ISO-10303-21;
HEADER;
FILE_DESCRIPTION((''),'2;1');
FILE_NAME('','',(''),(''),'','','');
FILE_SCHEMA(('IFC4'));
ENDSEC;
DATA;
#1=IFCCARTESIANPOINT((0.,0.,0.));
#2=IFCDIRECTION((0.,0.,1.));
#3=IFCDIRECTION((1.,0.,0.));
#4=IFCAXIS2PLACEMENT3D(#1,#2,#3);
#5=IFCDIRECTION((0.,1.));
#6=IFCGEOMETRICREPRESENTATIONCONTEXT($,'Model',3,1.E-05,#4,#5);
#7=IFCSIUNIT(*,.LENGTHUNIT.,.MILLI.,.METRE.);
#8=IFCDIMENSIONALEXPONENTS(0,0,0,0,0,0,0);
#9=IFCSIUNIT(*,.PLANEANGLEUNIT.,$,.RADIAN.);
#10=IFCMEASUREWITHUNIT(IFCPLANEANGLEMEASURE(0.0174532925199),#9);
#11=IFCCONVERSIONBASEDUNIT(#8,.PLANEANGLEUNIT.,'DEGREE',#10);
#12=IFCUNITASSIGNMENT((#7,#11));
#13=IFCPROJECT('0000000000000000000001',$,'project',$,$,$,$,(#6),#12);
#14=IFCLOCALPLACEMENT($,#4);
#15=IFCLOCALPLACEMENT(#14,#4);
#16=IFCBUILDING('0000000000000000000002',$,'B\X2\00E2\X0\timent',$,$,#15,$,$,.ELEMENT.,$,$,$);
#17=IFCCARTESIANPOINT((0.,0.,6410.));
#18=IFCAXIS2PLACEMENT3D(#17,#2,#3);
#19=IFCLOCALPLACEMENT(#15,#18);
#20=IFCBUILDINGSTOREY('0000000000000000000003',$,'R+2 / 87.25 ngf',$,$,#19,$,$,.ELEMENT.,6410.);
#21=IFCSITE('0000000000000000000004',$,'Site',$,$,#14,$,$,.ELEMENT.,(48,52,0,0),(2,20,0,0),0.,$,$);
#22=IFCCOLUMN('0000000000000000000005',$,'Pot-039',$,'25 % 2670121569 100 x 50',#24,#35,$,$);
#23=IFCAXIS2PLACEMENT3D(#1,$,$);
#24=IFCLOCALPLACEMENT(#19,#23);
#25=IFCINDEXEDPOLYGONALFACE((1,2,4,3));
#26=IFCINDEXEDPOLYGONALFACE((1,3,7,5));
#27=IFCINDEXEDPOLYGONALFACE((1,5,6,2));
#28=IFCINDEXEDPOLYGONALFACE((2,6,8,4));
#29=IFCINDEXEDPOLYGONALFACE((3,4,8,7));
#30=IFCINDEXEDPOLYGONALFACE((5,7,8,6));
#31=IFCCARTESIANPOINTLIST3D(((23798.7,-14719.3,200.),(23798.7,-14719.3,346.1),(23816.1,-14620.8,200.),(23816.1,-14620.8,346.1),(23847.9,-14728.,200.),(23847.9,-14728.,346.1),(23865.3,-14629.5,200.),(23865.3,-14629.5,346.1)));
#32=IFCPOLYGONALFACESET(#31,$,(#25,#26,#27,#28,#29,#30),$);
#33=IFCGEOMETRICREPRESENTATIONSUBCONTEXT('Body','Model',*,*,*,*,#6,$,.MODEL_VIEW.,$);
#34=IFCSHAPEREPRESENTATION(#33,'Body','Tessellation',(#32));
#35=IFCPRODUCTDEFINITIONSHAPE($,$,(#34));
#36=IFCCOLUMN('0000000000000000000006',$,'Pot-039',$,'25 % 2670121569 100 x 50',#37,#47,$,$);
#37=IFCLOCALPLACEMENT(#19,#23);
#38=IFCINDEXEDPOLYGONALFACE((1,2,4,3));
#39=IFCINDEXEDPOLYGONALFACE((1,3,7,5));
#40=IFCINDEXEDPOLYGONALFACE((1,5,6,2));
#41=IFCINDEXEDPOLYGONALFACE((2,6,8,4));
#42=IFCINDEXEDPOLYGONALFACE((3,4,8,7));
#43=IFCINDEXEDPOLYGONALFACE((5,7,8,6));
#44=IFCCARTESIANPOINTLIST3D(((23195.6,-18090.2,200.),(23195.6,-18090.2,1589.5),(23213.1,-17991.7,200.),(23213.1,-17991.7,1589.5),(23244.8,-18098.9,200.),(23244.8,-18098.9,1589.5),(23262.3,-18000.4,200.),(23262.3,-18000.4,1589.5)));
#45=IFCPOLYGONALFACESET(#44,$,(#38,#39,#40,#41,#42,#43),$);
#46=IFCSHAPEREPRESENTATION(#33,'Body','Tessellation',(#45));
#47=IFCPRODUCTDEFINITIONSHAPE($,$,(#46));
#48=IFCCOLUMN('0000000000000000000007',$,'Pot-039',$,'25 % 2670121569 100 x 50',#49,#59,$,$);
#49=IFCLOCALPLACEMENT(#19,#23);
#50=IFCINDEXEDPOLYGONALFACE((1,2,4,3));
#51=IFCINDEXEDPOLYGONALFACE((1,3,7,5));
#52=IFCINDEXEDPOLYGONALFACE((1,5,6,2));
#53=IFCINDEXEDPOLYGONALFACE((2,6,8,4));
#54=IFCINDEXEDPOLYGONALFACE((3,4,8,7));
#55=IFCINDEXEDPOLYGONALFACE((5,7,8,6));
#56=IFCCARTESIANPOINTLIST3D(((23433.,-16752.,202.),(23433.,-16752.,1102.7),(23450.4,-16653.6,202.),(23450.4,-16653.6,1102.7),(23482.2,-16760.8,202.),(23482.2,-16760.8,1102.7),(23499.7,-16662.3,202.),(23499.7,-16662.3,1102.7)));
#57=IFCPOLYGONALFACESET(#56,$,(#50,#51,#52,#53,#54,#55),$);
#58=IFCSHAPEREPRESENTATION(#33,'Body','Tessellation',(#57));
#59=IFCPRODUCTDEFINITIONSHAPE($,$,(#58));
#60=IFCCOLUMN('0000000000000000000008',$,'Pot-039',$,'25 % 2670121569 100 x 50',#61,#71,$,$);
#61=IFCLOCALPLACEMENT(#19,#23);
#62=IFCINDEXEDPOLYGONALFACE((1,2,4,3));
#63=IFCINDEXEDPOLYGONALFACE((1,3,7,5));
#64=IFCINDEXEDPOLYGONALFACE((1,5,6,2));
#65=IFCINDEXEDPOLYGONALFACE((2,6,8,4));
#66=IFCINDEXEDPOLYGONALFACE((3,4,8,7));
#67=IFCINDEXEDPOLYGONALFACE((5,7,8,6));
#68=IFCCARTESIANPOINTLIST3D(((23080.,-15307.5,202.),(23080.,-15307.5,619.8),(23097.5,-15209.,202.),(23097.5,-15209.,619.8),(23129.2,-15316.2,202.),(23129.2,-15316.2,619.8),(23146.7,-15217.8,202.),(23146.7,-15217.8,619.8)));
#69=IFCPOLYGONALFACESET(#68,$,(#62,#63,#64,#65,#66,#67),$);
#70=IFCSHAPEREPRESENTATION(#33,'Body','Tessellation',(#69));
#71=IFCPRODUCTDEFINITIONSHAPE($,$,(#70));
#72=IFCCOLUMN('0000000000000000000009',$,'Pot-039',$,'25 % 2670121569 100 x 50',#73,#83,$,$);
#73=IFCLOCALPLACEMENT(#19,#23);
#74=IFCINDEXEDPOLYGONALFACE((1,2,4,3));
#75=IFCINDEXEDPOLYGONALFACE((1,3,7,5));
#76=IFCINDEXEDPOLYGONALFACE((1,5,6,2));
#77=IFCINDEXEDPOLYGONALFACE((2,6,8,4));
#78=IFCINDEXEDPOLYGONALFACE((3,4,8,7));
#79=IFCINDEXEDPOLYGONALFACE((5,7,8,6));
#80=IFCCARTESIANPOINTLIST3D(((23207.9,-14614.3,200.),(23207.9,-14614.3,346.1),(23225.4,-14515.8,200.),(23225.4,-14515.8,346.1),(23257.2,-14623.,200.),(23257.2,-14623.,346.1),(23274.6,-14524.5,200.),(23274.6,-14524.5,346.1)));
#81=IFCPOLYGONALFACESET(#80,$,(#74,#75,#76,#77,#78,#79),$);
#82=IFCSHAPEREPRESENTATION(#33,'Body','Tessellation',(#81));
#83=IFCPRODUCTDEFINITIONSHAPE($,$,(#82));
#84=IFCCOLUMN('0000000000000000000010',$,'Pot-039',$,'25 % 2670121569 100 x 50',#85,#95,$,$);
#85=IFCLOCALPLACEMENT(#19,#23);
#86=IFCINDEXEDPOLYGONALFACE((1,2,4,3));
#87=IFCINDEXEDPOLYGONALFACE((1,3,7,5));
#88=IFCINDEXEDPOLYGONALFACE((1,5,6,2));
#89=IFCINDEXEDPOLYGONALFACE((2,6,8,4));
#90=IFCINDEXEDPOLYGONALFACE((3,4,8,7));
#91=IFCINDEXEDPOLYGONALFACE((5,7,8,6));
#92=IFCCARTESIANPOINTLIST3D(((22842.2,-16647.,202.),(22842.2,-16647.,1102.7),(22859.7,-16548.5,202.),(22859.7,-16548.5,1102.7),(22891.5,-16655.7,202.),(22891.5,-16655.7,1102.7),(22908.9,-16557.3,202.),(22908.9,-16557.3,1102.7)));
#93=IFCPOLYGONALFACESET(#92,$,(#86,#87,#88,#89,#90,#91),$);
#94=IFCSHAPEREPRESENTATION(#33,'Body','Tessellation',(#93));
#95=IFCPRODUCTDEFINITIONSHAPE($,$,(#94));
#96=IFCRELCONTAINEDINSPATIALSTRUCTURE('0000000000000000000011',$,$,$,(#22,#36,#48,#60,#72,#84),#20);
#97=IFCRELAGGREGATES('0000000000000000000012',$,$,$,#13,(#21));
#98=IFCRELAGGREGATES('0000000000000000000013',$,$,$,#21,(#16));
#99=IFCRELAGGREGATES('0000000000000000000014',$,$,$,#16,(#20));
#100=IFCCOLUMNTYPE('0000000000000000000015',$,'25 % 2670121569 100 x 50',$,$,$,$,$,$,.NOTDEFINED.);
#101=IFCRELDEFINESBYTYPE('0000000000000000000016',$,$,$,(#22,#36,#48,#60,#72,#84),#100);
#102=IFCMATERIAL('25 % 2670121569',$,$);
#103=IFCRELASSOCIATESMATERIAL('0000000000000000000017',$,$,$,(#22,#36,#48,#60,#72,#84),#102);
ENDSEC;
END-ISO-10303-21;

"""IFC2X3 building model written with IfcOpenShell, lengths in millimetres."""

from ifc_helpers import new_model, entity, si_unit, converted_unit, direction, frame, origin_with_axes, origin_2d_with_axis, place, context, subcontext, project, spatial, rectangle, extrude, material, type_object, element, save


model = new_model("IFC2X3")

# Units and contexts
model_context = context("Model", 3, precision=1e-05, world=origin_with_axes(), true_north=direction((0.0, 1.0)))
body_context = subcontext(model_context, "Body", "Model", "MODEL_VIEW")
ifc_project = project(units=[si_unit("LENGTHUNIT", "METRE", prefix="MILLI"), converted_unit("PLANEANGLEUNIT", "DEGREE", entity("IfcPlaneAngleMeasure", 0.0174532925199), si_unit("PLANEANGLEUNIT", "RADIAN"), dimensions=[0, 0, 0, 0, 0, 0, 0])], contexts=[model_context])

# Site, building, storey
site_placement = place(None, origin_with_axes())
site = spatial("IfcSite", under=ifc_project, at=site_placement, Name="Site", CompositionType="ELEMENT", RefLatitude=(48, 52, 0, 0), RefLongitude=(2, 20, 0, 0), RefElevation=0.0)
building_placement = place(site_placement, origin_with_axes())
building = spatial("IfcBuilding", under=site, at=building_placement, Name="Bâtiment", CompositionType="ELEMENT")
storey_placement = place(building_placement, frame((0.0, 0.0, 6410.0), z_axis=(0.0, 0.0, 1.0), x_axis=(1.0, 0.0, 0.0)))
storey = spatial("IfcBuildingStorey", under=building, at=storey_placement, Name="R+2 / 87.25 ngf", CompositionType="ELEMENT", Elevation=6410.0)

# Columns
ifc_material = material(Name="25 % 2670121569")
column_type = type_object("IfcColumnType", Name="25 % 2670121569 100 x 50", PredefinedType="NOTDEFINED")
column_1_placement = place(storey_placement, frame((23832.0, -14674.4, 200.0), z_axis=(0.0, 0.0, 1.0), x_axis=(0.174407, 0.984674, 0.0)))
element("IfcColumn", 1, at=column_1_placement, inside=storey, type_object=column_type, material=ifc_material, Name="Pot-039", ObjectType="25 % 2670121569 100 x 50", context=body_context, shape_type="SweptSolid", body=[
    extrude(rectangle(XDim=100.0, YDim=50.0, at=origin_2d_with_axis()), origin_with_axes(), (0.0, 0.0, 1.0), 146.1),
])
column_2_placement = place(storey_placement, frame((23228.9, -18045.3, 200.0), z_axis=(0.0, 0.0, 1.0), x_axis=(0.17478, 0.984607, 0.0)))
element("IfcColumn", 2, at=column_2_placement, inside=storey, type_object=column_type, material=ifc_material, Name="Pot-039", ObjectType="25 % 2670121569 100 x 50", context=body_context, shape_type="SweptSolid", body=[
    extrude(rectangle(XDim=100.0, YDim=50.0, at=origin_2d_with_axis()), origin_with_axes(), (0.0, 0.0, 1.0), 1389.5),
])
column_3_placement = place(storey_placement, frame((23466.3, -16707.2, 202.0), z_axis=(0.0, 0.0, 1.0), x_axis=(0.17478, 0.984607, 0.0)))
element("IfcColumn", 3, at=column_3_placement, inside=storey, type_object=column_type, material=ifc_material, Name="Pot-039", ObjectType="25 % 2670121569 100 x 50", context=body_context, shape_type="SweptSolid", body=[
    extrude(rectangle(XDim=100.0, YDim=50.0, at=origin_2d_with_axis()), origin_with_axes(), (0.0, 0.0, 1.0), 900.7),
])
column_4_placement = place(storey_placement, frame((23113.3, -15262.6, 202.0), z_axis=(0.0, 0.0, 1.0), x_axis=(0.17478, 0.984607, 0.0)))
element("IfcColumn", 4, at=column_4_placement, inside=storey, type_object=column_type, material=ifc_material, Name="Pot-039", ObjectType="25 % 2670121569 100 x 50", context=body_context, shape_type="SweptSolid", body=[
    extrude(rectangle(XDim=100.0, YDim=50.0, at=origin_2d_with_axis()), origin_with_axes(), (0.0, 0.0, 1.0), 417.8),
])
column_5_placement = place(storey_placement, frame((23241.3, -14569.4, 200.0), z_axis=(0.0, 0.0, 1.0), x_axis=(0.174407, 0.984674, 0.0)))
element("IfcColumn", 5, at=column_5_placement, inside=storey, type_object=column_type, material=ifc_material, Name="Pot-039", ObjectType="25 % 2670121569 100 x 50", context=body_context, shape_type="SweptSolid", body=[
    extrude(rectangle(XDim=100.0, YDim=50.0, at=origin_2d_with_axis()), origin_with_axes(), (0.0, 0.0, 1.0), 146.1),
])
column_6_placement = place(storey_placement, frame((22875.6, -16602.1, 202.0), z_axis=(0.0, 0.0, 1.0), x_axis=(0.17478, 0.984607, 0.0)))
element("IfcColumn", 6, at=column_6_placement, inside=storey, type_object=column_type, material=ifc_material, Name="Pot-039", ObjectType="25 % 2670121569 100 x 50", context=body_context, shape_type="SweptSolid", body=[
    extrude(rectangle(XDim=100.0, YDim=50.0, at=origin_2d_with_axis()), origin_with_axes(), (0.0, 0.0, 1.0), 900.7),
])

save(model, "model.ifc")
